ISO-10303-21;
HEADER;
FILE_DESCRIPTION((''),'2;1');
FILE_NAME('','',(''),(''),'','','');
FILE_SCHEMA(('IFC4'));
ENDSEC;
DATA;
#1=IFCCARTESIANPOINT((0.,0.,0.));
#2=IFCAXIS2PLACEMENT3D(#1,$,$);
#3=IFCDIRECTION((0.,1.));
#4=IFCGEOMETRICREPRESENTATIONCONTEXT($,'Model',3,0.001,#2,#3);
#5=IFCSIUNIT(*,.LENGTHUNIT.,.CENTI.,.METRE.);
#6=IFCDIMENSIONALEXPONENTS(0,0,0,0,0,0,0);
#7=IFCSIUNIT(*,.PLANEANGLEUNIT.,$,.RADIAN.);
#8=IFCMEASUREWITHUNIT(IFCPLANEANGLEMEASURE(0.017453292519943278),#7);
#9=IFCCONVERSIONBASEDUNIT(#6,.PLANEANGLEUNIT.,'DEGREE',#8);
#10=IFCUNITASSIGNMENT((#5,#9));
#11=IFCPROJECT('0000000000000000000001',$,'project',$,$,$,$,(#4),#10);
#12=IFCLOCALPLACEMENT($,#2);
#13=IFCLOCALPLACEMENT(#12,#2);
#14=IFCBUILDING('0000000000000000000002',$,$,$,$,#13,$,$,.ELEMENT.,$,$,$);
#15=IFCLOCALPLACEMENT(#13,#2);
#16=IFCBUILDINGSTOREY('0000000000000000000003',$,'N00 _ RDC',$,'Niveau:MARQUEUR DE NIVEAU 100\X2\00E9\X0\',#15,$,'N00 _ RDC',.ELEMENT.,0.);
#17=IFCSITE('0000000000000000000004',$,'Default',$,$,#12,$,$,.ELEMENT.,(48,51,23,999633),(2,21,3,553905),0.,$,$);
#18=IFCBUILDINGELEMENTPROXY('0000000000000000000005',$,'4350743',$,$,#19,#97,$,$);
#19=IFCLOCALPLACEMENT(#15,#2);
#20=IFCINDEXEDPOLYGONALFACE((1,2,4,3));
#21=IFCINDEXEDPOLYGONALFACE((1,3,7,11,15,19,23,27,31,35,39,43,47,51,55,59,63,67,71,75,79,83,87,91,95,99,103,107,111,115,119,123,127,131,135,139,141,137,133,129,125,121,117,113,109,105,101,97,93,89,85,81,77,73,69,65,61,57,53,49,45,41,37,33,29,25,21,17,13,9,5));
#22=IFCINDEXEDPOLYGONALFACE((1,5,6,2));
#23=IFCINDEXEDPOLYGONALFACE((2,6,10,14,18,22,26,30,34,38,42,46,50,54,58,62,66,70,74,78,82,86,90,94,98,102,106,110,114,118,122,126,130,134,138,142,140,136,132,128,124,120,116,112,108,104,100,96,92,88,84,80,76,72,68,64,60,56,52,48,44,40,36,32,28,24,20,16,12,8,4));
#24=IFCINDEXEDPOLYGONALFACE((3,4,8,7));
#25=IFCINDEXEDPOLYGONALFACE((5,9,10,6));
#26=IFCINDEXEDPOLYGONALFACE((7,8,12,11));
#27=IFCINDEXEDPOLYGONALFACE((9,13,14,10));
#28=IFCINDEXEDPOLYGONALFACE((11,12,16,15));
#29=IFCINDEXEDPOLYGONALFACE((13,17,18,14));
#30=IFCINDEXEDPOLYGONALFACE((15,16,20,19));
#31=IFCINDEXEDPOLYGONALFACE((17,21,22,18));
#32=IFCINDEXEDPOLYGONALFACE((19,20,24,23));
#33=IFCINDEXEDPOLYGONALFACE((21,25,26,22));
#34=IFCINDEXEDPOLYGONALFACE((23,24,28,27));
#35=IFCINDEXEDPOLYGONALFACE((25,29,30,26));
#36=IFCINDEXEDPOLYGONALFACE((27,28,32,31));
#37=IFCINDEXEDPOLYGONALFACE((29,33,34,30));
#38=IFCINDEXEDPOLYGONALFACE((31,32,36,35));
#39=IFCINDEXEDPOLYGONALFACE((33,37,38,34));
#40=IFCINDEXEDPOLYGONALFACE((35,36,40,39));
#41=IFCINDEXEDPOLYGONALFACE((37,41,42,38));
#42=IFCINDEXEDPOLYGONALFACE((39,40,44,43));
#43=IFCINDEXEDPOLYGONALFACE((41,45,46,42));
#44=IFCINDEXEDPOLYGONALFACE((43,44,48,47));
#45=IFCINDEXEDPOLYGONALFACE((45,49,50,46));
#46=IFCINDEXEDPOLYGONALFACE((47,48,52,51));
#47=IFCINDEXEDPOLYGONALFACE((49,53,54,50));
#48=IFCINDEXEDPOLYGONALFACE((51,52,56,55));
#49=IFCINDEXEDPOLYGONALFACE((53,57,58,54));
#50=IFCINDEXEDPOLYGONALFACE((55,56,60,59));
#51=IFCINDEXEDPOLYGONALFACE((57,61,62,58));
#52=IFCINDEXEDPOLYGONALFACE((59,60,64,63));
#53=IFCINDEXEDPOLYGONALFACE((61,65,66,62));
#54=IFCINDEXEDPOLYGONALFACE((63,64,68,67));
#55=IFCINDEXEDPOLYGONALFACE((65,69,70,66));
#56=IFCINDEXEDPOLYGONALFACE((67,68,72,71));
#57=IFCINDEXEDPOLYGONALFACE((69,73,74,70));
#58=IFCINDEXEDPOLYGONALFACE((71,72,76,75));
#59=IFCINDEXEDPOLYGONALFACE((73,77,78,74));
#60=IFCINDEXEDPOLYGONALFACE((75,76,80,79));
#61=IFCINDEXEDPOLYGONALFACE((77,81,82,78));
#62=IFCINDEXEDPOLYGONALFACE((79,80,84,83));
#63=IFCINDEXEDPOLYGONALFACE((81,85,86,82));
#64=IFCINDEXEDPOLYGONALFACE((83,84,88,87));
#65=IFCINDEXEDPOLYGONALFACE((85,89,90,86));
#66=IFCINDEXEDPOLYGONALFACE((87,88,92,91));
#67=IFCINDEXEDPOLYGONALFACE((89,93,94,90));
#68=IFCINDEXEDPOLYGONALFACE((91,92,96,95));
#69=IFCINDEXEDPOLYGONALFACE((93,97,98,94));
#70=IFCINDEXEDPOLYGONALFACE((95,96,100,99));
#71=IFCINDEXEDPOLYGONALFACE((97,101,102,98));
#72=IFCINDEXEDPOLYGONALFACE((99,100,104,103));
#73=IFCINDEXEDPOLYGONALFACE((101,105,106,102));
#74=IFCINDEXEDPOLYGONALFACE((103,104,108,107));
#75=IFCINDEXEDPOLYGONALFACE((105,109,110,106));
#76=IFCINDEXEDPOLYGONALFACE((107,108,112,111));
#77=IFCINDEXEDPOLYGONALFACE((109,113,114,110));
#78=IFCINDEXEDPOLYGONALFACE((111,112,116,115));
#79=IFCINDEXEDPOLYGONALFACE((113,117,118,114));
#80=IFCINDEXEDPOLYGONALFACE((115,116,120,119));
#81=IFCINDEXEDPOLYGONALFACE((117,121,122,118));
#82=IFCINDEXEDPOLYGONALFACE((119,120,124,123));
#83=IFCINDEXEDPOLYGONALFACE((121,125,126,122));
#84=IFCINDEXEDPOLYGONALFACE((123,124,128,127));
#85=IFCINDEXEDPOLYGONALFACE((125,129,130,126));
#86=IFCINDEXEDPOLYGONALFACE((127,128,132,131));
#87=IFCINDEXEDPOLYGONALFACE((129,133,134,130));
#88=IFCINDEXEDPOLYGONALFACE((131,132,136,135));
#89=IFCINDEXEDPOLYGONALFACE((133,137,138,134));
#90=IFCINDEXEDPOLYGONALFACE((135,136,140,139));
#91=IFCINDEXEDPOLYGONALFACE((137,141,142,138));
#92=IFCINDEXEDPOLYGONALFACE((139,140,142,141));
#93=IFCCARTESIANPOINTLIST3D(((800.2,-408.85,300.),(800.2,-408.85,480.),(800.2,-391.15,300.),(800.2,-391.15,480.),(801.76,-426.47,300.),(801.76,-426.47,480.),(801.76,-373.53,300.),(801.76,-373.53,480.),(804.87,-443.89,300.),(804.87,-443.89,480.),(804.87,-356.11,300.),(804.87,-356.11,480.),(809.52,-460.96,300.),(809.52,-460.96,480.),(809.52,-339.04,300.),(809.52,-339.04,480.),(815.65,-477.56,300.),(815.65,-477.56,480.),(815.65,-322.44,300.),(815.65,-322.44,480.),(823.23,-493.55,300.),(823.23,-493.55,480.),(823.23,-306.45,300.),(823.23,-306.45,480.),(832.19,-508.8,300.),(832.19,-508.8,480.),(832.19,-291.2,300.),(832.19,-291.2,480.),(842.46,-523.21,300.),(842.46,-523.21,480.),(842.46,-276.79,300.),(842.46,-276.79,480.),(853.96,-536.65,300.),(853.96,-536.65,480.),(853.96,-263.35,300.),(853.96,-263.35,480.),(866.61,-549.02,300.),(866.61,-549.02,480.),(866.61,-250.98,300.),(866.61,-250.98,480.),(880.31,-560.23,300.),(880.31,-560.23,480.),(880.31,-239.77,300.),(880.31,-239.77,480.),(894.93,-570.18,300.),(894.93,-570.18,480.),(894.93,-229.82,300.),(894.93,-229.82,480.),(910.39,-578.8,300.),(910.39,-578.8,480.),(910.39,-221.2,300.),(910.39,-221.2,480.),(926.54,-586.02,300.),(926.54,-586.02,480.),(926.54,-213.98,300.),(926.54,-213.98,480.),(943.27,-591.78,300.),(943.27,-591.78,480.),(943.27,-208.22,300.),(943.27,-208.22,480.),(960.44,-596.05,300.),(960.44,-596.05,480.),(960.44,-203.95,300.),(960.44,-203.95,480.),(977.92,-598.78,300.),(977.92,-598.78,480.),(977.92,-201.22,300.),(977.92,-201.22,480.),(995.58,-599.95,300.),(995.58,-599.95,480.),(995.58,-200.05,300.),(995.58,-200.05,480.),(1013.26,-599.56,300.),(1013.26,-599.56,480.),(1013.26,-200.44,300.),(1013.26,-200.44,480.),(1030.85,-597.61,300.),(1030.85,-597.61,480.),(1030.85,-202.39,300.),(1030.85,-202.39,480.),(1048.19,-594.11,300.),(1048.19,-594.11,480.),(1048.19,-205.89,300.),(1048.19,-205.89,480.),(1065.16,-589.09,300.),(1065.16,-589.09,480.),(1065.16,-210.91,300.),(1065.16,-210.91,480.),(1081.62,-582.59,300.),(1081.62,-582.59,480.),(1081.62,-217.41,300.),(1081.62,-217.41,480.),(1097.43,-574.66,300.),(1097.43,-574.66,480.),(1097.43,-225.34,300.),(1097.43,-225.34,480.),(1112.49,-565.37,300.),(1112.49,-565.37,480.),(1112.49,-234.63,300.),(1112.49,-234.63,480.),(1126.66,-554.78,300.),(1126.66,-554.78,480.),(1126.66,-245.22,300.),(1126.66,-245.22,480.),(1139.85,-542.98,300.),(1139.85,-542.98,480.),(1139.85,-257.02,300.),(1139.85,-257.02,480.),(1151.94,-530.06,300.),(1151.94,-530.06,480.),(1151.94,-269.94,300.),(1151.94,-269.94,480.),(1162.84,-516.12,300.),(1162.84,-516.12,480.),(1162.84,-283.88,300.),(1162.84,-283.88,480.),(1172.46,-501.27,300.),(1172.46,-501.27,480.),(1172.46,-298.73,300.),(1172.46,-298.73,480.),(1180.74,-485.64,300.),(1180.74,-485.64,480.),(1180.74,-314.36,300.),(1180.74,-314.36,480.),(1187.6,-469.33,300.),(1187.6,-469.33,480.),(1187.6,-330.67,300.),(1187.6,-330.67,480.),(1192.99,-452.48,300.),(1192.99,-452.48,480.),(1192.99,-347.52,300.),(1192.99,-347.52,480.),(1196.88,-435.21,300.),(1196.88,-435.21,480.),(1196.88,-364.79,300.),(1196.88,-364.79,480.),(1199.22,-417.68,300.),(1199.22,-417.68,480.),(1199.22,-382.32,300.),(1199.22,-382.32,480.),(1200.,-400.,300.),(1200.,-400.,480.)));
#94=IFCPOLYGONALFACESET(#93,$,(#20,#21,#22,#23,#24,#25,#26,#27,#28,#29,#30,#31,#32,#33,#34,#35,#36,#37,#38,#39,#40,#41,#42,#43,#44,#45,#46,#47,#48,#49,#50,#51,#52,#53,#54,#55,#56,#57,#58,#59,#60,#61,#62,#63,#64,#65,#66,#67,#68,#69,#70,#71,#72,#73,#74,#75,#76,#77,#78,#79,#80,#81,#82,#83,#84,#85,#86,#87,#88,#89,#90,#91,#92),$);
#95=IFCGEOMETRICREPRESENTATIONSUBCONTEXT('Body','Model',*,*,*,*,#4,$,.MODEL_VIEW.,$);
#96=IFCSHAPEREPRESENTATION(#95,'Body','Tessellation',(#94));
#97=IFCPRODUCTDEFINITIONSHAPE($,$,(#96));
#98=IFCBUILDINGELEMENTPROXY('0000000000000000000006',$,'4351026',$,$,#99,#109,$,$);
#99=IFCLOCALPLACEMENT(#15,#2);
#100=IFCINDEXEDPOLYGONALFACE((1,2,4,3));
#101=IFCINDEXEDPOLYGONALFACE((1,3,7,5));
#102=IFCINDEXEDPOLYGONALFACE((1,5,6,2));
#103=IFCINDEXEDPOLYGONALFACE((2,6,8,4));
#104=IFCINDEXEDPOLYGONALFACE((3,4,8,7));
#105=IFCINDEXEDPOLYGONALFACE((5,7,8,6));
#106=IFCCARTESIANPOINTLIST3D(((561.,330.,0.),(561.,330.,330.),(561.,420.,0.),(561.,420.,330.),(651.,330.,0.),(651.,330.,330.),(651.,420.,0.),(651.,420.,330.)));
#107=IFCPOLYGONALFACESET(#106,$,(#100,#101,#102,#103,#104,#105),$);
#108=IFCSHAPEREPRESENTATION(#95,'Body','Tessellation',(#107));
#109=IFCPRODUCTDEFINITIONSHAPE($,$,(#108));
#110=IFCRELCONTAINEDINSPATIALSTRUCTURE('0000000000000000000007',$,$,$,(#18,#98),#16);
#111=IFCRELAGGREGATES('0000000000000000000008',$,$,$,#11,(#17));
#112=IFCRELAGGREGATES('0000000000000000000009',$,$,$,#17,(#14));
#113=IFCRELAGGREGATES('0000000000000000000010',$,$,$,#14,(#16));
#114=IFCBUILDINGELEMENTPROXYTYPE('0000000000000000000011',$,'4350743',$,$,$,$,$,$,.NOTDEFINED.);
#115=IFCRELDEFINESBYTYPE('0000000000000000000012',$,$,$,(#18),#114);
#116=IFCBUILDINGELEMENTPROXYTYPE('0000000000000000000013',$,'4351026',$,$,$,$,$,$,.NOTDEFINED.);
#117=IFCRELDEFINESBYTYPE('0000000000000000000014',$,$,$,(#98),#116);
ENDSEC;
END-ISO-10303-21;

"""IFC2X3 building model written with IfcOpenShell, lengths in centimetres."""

from ifc_helpers import new_model, entity, si_unit, converted_unit, direction, frame, frame_2d, origin, origin_2d_with_axis, place, context, subcontext, project, spatial, rectangle, circle, extrude, type_object, element, save


model = new_model("IFC2X3")

# Units and contexts
model_context = context("Model", 3, precision=0.001, world=origin(), true_north=direction((0.0, 1.0)))
body_context = subcontext(model_context, "Body", "Model", "MODEL_VIEW")
ifc_project = project(units=[si_unit("LENGTHUNIT", "METRE", prefix="CENTI"), converted_unit("PLANEANGLEUNIT", "DEGREE", entity("IfcPlaneAngleMeasure", 0.017453292519943278), si_unit("PLANEANGLEUNIT", "RADIAN"), dimensions=[0, 0, 0, 0, 0, 0, 0])], contexts=[model_context])

# Site, building, storey
site_placement = place(None, origin())
site = spatial("IfcSite", under=ifc_project, at=site_placement, Name="Default", CompositionType="ELEMENT", RefLatitude=(48, 51, 23, 999633), RefLongitude=(2, 21, 3, 553905), RefElevation=0.0)
building_placement = place(site_placement, origin())
building = spatial("IfcBuilding", under=site, at=building_placement, CompositionType="ELEMENT")
storey_placement = place(building_placement, origin())
storey = spatial("IfcBuildingStorey", under=building, at=storey_placement, Name="N00 _ RDC", ObjectType="Niveau:MARQUEUR DE NIVEAU 100é", LongName="N00 _ RDC", CompositionType="ELEMENT", Elevation=0.0)

# Building element proxies
building_element_proxy_type_1 = type_object("IfcBuildingElementProxyType", Name="4350743", PredefinedType="NOTDEFINED")
proxy_1_placement = place(storey_placement, origin())
element("IfcBuildingElementProxy", 1, at=proxy_1_placement, inside=storey, type_object=building_element_proxy_type_1, Name="4350743", context=body_context, shape_type="SweptSolid", body=[
    extrude(circle(Radius=200.0, at=origin_2d_with_axis()), frame((1000.0, -400.0, 300.0)), (0.0, 0.0, 1.0), 180.0),
])
building_element_proxy_type_2 = type_object("IfcBuildingElementProxyType", Name="4351026", PredefinedType="NOTDEFINED")
proxy_2_placement = place(storey_placement, origin())
element("IfcBuildingElementProxy", 2, at=proxy_2_placement, inside=storey, type_object=building_element_proxy_type_2, Name="4351026", context=body_context, shape_type="SweptSolid", body=[
    extrude(rectangle(XDim=90.0, YDim=90.0, at=frame_2d((0.0, 0.0), x_axis=(1.0, 0.0))), frame((606.0, 375.0, 0.0)), (0.0, 0.0, 1.0), 330.0),
])

save(model, "model.ifc")
